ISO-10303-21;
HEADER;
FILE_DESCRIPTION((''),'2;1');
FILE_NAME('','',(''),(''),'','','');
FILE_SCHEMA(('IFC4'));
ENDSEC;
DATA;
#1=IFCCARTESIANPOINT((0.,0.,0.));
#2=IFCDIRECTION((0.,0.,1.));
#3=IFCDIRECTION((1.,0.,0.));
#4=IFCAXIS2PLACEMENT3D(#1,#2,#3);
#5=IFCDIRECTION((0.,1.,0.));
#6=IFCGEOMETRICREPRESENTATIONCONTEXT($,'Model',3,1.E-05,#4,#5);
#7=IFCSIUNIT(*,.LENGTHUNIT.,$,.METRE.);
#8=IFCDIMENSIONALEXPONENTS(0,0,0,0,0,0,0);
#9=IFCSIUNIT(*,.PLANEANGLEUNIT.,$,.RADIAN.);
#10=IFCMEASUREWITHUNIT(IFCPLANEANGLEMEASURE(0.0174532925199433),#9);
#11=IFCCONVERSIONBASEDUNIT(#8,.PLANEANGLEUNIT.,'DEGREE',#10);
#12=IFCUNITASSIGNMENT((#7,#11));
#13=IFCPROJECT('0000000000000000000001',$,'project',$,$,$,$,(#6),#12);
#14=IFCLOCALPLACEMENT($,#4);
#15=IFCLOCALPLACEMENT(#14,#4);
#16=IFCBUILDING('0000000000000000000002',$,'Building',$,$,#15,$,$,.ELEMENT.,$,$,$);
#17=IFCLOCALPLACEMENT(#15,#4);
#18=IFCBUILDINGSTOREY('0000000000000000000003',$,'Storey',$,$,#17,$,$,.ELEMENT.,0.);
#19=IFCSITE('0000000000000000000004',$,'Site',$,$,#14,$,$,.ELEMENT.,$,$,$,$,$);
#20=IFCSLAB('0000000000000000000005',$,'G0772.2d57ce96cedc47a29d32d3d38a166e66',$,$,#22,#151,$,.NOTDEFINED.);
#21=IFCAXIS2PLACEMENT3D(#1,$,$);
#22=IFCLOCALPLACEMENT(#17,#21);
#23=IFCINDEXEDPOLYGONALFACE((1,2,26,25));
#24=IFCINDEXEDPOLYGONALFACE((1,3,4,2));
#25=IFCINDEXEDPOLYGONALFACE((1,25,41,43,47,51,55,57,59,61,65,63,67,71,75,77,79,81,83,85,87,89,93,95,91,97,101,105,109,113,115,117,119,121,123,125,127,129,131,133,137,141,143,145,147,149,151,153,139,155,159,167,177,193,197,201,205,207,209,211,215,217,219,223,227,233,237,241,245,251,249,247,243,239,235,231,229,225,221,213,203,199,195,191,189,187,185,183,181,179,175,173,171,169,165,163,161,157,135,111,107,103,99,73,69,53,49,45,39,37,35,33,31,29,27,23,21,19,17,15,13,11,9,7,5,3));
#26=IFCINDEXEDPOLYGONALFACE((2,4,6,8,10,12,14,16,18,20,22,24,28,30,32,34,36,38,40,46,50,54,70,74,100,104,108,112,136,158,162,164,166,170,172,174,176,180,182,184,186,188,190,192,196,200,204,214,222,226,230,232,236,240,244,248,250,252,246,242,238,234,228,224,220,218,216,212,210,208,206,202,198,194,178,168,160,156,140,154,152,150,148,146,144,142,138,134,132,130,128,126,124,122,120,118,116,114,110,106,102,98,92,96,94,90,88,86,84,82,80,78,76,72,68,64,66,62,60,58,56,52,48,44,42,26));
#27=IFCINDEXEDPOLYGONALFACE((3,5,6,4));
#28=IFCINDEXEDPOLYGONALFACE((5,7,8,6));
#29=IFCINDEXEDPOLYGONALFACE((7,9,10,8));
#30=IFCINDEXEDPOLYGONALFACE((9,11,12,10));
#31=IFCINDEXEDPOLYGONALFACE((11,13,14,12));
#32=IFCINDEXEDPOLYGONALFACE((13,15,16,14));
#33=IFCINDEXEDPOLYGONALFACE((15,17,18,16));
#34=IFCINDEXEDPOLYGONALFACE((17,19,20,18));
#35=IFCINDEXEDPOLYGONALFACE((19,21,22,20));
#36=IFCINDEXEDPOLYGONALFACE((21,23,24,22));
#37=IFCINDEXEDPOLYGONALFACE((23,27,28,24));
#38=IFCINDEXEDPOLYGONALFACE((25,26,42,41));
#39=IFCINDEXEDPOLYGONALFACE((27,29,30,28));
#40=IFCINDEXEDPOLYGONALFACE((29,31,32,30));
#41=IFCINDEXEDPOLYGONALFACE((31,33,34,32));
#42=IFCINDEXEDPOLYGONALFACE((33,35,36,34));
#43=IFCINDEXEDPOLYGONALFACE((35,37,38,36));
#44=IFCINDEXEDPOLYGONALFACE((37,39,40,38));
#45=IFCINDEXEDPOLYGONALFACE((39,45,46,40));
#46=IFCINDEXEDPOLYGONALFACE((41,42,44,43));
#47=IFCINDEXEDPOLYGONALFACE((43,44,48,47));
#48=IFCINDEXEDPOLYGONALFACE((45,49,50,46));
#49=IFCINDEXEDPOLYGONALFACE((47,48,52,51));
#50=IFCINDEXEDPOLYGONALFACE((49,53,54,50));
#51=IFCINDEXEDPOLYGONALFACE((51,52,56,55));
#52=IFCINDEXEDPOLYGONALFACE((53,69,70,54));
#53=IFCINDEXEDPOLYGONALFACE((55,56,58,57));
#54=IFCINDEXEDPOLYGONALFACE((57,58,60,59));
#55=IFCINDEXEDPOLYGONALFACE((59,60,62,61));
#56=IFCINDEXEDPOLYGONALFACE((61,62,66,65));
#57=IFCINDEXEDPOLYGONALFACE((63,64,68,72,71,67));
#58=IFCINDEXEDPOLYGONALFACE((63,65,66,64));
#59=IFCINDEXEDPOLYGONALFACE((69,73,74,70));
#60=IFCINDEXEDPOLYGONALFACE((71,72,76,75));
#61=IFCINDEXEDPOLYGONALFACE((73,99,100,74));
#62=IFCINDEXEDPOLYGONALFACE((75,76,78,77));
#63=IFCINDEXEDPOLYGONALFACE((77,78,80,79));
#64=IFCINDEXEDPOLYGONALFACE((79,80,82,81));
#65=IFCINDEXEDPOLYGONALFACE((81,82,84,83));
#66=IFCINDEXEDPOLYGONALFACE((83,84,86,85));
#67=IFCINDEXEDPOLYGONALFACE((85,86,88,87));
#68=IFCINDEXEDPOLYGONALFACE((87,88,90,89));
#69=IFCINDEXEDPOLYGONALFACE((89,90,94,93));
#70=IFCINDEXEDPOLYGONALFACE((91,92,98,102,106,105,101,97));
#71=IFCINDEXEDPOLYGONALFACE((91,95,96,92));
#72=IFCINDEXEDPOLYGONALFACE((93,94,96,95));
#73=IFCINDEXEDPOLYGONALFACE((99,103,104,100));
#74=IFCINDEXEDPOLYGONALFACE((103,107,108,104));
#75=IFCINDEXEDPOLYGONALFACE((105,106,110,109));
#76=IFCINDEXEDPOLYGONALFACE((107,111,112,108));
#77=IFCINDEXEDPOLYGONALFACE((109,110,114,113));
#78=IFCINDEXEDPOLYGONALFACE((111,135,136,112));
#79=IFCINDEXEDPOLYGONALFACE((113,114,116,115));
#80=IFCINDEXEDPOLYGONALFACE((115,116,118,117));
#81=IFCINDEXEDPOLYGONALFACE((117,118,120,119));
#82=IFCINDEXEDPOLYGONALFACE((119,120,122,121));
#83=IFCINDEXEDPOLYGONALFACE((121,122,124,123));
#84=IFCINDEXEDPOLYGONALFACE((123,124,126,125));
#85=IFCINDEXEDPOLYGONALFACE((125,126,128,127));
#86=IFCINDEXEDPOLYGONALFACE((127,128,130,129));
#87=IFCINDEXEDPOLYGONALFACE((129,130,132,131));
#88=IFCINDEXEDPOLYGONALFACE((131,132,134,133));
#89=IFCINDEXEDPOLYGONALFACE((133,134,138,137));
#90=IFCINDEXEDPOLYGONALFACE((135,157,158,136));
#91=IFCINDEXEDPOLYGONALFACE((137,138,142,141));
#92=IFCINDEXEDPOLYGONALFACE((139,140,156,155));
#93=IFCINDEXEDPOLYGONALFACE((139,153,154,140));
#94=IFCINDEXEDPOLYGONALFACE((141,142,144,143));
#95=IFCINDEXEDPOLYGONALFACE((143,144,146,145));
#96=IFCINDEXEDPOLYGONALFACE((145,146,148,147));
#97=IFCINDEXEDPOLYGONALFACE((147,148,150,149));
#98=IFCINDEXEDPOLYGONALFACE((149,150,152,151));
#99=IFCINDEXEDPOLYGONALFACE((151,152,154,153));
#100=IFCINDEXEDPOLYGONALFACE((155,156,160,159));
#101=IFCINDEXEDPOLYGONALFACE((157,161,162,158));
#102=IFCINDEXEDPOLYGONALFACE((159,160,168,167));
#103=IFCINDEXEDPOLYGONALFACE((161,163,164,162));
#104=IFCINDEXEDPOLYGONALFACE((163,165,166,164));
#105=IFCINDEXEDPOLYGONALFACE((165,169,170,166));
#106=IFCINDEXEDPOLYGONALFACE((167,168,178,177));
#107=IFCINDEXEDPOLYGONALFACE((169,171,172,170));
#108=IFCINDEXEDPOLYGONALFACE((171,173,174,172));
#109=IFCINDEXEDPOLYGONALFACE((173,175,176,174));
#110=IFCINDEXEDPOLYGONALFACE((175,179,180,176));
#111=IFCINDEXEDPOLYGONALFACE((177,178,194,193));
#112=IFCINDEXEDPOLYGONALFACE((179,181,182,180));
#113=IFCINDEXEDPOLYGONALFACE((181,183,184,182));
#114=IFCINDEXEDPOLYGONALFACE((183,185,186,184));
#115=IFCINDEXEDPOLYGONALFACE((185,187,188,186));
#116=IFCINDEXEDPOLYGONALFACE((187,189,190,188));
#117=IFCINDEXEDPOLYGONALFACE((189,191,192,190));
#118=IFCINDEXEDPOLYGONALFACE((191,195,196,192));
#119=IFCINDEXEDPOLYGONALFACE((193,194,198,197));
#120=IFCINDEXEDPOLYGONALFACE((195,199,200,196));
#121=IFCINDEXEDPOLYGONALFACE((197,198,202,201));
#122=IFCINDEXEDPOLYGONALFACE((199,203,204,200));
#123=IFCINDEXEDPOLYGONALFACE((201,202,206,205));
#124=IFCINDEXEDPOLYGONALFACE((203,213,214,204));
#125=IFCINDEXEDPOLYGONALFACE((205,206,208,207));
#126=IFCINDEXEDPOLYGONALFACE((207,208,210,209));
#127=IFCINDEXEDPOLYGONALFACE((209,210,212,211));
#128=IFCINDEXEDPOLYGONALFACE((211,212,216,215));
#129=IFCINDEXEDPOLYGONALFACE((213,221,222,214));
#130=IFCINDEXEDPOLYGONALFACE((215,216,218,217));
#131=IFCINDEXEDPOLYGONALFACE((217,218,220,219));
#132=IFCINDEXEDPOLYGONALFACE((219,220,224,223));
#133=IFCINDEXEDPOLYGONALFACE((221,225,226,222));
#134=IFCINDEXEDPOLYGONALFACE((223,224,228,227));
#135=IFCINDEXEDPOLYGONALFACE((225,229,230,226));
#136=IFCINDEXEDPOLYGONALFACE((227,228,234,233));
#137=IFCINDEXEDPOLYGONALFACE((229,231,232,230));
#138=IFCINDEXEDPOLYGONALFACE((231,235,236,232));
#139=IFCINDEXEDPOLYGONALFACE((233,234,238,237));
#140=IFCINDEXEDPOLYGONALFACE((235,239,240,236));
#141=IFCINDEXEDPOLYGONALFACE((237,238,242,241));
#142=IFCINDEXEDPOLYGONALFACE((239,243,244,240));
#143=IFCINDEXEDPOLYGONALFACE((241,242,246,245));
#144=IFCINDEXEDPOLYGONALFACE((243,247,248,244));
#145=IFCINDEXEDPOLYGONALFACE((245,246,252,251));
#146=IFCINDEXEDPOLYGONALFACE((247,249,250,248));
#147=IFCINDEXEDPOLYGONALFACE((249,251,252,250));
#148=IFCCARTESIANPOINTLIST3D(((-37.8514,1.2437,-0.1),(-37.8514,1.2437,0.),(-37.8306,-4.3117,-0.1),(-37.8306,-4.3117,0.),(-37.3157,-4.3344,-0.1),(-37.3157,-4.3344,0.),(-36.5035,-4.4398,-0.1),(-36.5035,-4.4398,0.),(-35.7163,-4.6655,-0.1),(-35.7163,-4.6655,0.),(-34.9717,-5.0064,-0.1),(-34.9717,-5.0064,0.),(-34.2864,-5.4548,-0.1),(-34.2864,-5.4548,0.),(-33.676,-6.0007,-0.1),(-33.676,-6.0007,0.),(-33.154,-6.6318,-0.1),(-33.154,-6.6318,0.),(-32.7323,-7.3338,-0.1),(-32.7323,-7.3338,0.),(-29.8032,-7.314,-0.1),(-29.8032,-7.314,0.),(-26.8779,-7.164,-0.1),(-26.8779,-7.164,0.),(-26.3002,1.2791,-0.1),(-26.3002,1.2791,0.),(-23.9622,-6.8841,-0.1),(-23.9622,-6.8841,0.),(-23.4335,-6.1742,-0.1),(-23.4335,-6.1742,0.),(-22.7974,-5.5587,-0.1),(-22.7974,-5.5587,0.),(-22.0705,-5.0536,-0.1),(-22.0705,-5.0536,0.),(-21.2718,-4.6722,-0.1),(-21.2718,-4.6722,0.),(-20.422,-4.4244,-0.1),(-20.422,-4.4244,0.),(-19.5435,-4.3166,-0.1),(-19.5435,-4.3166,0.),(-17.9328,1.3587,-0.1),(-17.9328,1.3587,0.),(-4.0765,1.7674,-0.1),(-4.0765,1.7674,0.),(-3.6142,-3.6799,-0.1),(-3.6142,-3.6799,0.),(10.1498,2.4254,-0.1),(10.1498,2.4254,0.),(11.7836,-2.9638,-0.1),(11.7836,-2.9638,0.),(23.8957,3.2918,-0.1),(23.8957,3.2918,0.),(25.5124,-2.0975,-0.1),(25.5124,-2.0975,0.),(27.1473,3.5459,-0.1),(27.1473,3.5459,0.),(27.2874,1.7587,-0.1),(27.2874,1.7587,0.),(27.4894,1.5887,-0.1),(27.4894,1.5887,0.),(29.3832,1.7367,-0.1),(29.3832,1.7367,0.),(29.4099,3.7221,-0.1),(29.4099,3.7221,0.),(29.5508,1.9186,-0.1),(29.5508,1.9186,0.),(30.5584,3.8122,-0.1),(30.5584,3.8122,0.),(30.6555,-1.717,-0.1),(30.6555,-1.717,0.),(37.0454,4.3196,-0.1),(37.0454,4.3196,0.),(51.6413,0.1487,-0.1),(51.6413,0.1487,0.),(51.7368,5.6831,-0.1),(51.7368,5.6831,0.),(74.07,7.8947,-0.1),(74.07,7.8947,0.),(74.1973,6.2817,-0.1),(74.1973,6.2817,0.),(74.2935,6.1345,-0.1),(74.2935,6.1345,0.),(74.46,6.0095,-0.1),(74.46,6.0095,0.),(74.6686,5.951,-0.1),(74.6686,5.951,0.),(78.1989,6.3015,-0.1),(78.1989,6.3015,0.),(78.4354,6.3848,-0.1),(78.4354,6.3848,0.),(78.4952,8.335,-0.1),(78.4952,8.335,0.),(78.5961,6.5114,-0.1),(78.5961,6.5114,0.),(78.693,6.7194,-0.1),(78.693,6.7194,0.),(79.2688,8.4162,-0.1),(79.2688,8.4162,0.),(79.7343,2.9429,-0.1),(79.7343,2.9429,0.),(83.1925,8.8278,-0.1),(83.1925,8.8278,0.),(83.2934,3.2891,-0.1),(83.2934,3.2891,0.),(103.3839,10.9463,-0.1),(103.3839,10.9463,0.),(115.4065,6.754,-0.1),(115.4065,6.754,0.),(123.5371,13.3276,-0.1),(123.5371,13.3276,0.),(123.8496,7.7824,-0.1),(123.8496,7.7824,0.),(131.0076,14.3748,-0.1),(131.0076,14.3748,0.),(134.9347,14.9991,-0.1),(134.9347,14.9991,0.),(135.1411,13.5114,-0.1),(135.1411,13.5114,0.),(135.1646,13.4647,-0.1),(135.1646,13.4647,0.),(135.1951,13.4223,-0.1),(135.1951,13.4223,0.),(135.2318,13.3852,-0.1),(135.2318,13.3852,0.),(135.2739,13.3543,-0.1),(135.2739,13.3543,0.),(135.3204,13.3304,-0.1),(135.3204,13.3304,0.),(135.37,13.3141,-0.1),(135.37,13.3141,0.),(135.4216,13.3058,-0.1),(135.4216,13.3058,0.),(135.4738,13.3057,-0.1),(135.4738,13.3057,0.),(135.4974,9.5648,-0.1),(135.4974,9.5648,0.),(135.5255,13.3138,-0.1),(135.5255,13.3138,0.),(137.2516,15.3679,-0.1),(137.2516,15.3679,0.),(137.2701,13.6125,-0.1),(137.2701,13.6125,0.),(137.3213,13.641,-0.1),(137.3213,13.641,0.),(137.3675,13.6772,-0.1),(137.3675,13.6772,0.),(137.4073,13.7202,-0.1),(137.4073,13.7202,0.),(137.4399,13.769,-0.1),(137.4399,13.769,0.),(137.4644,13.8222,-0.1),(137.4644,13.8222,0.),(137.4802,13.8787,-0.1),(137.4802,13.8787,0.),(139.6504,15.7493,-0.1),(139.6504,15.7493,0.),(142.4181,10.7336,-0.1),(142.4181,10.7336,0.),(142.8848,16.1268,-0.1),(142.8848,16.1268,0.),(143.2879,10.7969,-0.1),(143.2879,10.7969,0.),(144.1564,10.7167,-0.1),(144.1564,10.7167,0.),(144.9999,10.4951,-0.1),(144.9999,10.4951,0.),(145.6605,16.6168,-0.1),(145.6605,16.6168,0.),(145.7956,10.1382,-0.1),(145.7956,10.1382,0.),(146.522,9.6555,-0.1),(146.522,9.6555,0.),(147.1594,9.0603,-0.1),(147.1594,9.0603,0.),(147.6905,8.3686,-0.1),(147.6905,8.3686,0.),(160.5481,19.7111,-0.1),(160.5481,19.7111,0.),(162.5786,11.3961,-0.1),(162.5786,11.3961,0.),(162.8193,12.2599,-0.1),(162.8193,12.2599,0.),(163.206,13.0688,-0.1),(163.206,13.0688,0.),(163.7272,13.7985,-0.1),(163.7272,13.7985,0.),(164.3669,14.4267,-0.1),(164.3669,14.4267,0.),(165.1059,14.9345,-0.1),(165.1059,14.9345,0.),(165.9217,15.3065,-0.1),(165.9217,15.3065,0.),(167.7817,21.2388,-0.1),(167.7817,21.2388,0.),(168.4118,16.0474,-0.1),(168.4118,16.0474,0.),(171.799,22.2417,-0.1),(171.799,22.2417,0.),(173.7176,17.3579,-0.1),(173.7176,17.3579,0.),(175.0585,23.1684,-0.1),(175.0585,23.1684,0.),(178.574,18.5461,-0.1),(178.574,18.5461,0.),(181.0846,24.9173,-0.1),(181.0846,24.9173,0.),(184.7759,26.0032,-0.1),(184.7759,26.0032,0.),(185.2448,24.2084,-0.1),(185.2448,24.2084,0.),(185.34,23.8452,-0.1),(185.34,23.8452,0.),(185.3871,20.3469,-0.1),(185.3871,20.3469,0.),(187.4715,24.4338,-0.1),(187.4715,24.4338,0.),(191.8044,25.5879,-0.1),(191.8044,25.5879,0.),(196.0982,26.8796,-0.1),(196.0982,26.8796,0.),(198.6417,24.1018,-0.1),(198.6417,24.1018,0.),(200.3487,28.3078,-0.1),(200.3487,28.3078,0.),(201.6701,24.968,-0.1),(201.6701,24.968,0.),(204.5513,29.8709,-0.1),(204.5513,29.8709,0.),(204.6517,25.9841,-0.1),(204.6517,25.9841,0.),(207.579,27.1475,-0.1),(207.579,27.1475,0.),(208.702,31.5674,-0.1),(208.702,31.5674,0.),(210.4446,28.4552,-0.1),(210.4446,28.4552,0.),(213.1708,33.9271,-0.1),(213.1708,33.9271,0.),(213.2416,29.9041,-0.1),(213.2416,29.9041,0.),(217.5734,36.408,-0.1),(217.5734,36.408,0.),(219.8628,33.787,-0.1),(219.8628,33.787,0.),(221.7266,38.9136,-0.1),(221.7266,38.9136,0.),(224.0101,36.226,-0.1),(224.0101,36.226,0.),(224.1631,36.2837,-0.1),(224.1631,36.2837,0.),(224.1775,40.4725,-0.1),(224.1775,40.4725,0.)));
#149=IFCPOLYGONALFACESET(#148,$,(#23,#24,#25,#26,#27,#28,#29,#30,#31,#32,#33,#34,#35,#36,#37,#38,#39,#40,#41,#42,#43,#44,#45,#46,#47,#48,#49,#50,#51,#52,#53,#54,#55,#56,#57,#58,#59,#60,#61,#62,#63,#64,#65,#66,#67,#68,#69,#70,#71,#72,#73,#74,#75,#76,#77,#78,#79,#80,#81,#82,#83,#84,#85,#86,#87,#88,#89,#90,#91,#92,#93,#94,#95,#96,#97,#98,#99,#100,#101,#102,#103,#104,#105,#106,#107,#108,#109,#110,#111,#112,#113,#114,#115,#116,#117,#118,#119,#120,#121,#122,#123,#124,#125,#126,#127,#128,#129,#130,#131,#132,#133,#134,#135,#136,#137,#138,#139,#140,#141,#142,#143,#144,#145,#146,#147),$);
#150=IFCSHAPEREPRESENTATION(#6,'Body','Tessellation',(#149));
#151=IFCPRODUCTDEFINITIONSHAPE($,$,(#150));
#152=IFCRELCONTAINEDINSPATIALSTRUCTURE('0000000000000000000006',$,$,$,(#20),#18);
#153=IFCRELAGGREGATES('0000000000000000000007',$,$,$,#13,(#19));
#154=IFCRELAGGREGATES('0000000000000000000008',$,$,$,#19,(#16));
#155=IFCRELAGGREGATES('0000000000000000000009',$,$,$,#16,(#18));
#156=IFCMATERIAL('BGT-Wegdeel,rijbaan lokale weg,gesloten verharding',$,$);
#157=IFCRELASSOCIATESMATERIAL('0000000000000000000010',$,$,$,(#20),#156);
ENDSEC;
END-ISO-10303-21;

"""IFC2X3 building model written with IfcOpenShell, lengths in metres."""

from ifc_helpers import new_model, entity, si_unit, converted_unit, direction, frame, origin_with_axes, place, context, project, spatial, polyline, outline, extrude, material, element, save


model = new_model("IFC2X3")

# Units and contexts
model_context = context("Model", 3, precision=1e-05, world=origin_with_axes(), true_north=direction((0.0, 1.0, 0.0)))
ifc_project = project(units=[si_unit("LENGTHUNIT", "METRE"), converted_unit("PLANEANGLEUNIT", "DEGREE", entity("IfcPlaneAngleMeasure", 0.0174532925199433), si_unit("PLANEANGLEUNIT", "RADIAN"), dimensions=[0, 0, 0, 0, 0, 0, 0])], contexts=[model_context])

# Site, building, storey
site_placement = place(None, origin_with_axes())
site = spatial("IfcSite", under=ifc_project, at=site_placement, Name="Site", CompositionType="ELEMENT")
building_placement = place(site_placement, origin_with_axes())
building = spatial("IfcBuilding", under=site, at=building_placement, Name="Building", CompositionType="ELEMENT")
storey_placement = place(building_placement, origin_with_axes())
storey = spatial("IfcBuildingStorey", under=building, at=storey_placement, Name="Storey", CompositionType="ELEMENT", Elevation=0.0)

# Slab
ifc_material_1 = material(Name="BGT-Wegdeel,rijbaan lokale weg,gesloten verharding")
slab_1_placement = place(storey_placement, frame((0.0, 0.0, -0.1), z_axis=(0.0, 0.0, 1.0), x_axis=(1.0, 0.0, 0.0)))
element("IfcSlab", 1, at=slab_1_placement, inside=storey, material=ifc_material_1, Name="G0772.2d57ce96cedc47a29d32d3d38a166e66", PredefinedType="NOTDEFINED", context=model_context, shape_type="SweptSolid", body=[
    extrude(outline(polyline([(37.0454, 4.3196), (51.7368, 5.6831), (74.07, 7.8947), (74.1973, 6.2817), (74.2935, 6.1345), (74.46, 6.0095), (74.6686, 5.951), (78.1989, 6.3015), (78.4354, 6.3848), (78.5961, 6.5114), (78.693, 6.7194), (78.4952, 8.335), (79.2688, 8.4162), (83.1925, 8.8278), (103.3839, 10.9463), (123.5371, 13.3276), (131.0076, 14.3748), (134.9347, 14.9991), (135.1411, 13.5114), (135.1646, 13.4647), (135.1951, 13.4223), (135.2318, 13.3852), (135.2739, 13.3543), (135.3204, 13.3304), (135.37, 13.3141), (135.4216, 13.3058), (135.4738, 13.3057), (135.5255, 13.3138), (137.2701, 13.6125), (137.3213, 13.641), (137.3675, 13.6772), (137.4073, 13.7202), (137.4399, 13.769), (137.4644, 13.8222), (137.4802, 13.8787), (137.2516, 15.3679), (139.6504, 15.7493), (142.8848, 16.1268), (145.6605, 16.6168), (160.5481, 19.7111), (167.7817, 21.2388), (171.799, 22.2417), (175.0585, 23.1684), (181.0846, 24.9173), (184.7759, 26.0032), (185.2448, 24.2084), (185.34, 23.8452), (187.4715, 24.4338), (191.8044, 25.5879), (196.0982, 26.8796), (200.3487, 28.3078), (204.5513, 29.8709), (208.702, 31.5674), (213.1708, 33.9271), (217.5734, 36.408), (221.7266, 38.9136), (224.1775, 40.4725), (224.1631, 36.2837), (224.0101, 36.226), (219.8628, 33.787), (213.2416, 29.9041), (210.4446, 28.4552), (207.579, 27.1475), (204.6517, 25.9841), (201.6701, 24.968), (198.6417, 24.1018), (185.3871, 20.3469), (178.574, 18.5461), (173.7176, 17.3579), (168.4118, 16.0474), (165.9217, 15.3065), (165.1059, 14.9345), (164.3669, 14.4267), (163.7272, 13.7985), (163.206, 13.0688), (162.8193, 12.2599), (162.5786, 11.3961), (147.6905, 8.3686), (147.1594, 9.0603), (146.522, 9.6555), (145.7956, 10.1382), (144.9999, 10.4951), (144.1564, 10.7167), (143.2879, 10.7969), (142.4181, 10.7336), (135.4974, 9.5648), (123.8496, 7.7824), (115.4065, 6.754), (83.2934, 3.2891), (79.7343, 2.9429), (51.6413, 0.1487), (30.6555, -1.717), (25.5124, -2.0975), (11.7836, -2.9638), (-3.6142, -3.6799), (-19.5435, -4.3166), (-20.422, -4.4244), (-21.2718, -4.6722), (-22.0705, -5.0536), (-22.7974, -5.5587), (-23.4335, -6.1742), (-23.9622, -6.8841), (-26.8779, -7.164), (-29.8032, -7.314), (-32.7323, -7.3338), (-33.154, -6.6318), (-33.676, -6.0007), (-34.2864, -5.4548), (-34.9717, -5.0064), (-35.7163, -4.6655), (-36.5035, -4.4398), (-37.3157, -4.3344), (-37.8306, -4.3117), (-37.8514, 1.2437), (-26.3002, 1.2791), (-17.9328, 1.3587), (-4.0765, 1.7674), (10.1498, 2.4254), (23.8957, 3.2918), (27.1473, 3.5459), (27.2874, 1.7587), (27.4894, 1.5887), (29.3832, 1.7367), (29.5508, 1.9186), (29.4099, 3.7221), (30.5584, 3.8122), (37.0454, 4.3196)])), origin_with_axes(), (0.0, 0.0, 1.0), 0.1),
])

save(model, "model.ifc")
